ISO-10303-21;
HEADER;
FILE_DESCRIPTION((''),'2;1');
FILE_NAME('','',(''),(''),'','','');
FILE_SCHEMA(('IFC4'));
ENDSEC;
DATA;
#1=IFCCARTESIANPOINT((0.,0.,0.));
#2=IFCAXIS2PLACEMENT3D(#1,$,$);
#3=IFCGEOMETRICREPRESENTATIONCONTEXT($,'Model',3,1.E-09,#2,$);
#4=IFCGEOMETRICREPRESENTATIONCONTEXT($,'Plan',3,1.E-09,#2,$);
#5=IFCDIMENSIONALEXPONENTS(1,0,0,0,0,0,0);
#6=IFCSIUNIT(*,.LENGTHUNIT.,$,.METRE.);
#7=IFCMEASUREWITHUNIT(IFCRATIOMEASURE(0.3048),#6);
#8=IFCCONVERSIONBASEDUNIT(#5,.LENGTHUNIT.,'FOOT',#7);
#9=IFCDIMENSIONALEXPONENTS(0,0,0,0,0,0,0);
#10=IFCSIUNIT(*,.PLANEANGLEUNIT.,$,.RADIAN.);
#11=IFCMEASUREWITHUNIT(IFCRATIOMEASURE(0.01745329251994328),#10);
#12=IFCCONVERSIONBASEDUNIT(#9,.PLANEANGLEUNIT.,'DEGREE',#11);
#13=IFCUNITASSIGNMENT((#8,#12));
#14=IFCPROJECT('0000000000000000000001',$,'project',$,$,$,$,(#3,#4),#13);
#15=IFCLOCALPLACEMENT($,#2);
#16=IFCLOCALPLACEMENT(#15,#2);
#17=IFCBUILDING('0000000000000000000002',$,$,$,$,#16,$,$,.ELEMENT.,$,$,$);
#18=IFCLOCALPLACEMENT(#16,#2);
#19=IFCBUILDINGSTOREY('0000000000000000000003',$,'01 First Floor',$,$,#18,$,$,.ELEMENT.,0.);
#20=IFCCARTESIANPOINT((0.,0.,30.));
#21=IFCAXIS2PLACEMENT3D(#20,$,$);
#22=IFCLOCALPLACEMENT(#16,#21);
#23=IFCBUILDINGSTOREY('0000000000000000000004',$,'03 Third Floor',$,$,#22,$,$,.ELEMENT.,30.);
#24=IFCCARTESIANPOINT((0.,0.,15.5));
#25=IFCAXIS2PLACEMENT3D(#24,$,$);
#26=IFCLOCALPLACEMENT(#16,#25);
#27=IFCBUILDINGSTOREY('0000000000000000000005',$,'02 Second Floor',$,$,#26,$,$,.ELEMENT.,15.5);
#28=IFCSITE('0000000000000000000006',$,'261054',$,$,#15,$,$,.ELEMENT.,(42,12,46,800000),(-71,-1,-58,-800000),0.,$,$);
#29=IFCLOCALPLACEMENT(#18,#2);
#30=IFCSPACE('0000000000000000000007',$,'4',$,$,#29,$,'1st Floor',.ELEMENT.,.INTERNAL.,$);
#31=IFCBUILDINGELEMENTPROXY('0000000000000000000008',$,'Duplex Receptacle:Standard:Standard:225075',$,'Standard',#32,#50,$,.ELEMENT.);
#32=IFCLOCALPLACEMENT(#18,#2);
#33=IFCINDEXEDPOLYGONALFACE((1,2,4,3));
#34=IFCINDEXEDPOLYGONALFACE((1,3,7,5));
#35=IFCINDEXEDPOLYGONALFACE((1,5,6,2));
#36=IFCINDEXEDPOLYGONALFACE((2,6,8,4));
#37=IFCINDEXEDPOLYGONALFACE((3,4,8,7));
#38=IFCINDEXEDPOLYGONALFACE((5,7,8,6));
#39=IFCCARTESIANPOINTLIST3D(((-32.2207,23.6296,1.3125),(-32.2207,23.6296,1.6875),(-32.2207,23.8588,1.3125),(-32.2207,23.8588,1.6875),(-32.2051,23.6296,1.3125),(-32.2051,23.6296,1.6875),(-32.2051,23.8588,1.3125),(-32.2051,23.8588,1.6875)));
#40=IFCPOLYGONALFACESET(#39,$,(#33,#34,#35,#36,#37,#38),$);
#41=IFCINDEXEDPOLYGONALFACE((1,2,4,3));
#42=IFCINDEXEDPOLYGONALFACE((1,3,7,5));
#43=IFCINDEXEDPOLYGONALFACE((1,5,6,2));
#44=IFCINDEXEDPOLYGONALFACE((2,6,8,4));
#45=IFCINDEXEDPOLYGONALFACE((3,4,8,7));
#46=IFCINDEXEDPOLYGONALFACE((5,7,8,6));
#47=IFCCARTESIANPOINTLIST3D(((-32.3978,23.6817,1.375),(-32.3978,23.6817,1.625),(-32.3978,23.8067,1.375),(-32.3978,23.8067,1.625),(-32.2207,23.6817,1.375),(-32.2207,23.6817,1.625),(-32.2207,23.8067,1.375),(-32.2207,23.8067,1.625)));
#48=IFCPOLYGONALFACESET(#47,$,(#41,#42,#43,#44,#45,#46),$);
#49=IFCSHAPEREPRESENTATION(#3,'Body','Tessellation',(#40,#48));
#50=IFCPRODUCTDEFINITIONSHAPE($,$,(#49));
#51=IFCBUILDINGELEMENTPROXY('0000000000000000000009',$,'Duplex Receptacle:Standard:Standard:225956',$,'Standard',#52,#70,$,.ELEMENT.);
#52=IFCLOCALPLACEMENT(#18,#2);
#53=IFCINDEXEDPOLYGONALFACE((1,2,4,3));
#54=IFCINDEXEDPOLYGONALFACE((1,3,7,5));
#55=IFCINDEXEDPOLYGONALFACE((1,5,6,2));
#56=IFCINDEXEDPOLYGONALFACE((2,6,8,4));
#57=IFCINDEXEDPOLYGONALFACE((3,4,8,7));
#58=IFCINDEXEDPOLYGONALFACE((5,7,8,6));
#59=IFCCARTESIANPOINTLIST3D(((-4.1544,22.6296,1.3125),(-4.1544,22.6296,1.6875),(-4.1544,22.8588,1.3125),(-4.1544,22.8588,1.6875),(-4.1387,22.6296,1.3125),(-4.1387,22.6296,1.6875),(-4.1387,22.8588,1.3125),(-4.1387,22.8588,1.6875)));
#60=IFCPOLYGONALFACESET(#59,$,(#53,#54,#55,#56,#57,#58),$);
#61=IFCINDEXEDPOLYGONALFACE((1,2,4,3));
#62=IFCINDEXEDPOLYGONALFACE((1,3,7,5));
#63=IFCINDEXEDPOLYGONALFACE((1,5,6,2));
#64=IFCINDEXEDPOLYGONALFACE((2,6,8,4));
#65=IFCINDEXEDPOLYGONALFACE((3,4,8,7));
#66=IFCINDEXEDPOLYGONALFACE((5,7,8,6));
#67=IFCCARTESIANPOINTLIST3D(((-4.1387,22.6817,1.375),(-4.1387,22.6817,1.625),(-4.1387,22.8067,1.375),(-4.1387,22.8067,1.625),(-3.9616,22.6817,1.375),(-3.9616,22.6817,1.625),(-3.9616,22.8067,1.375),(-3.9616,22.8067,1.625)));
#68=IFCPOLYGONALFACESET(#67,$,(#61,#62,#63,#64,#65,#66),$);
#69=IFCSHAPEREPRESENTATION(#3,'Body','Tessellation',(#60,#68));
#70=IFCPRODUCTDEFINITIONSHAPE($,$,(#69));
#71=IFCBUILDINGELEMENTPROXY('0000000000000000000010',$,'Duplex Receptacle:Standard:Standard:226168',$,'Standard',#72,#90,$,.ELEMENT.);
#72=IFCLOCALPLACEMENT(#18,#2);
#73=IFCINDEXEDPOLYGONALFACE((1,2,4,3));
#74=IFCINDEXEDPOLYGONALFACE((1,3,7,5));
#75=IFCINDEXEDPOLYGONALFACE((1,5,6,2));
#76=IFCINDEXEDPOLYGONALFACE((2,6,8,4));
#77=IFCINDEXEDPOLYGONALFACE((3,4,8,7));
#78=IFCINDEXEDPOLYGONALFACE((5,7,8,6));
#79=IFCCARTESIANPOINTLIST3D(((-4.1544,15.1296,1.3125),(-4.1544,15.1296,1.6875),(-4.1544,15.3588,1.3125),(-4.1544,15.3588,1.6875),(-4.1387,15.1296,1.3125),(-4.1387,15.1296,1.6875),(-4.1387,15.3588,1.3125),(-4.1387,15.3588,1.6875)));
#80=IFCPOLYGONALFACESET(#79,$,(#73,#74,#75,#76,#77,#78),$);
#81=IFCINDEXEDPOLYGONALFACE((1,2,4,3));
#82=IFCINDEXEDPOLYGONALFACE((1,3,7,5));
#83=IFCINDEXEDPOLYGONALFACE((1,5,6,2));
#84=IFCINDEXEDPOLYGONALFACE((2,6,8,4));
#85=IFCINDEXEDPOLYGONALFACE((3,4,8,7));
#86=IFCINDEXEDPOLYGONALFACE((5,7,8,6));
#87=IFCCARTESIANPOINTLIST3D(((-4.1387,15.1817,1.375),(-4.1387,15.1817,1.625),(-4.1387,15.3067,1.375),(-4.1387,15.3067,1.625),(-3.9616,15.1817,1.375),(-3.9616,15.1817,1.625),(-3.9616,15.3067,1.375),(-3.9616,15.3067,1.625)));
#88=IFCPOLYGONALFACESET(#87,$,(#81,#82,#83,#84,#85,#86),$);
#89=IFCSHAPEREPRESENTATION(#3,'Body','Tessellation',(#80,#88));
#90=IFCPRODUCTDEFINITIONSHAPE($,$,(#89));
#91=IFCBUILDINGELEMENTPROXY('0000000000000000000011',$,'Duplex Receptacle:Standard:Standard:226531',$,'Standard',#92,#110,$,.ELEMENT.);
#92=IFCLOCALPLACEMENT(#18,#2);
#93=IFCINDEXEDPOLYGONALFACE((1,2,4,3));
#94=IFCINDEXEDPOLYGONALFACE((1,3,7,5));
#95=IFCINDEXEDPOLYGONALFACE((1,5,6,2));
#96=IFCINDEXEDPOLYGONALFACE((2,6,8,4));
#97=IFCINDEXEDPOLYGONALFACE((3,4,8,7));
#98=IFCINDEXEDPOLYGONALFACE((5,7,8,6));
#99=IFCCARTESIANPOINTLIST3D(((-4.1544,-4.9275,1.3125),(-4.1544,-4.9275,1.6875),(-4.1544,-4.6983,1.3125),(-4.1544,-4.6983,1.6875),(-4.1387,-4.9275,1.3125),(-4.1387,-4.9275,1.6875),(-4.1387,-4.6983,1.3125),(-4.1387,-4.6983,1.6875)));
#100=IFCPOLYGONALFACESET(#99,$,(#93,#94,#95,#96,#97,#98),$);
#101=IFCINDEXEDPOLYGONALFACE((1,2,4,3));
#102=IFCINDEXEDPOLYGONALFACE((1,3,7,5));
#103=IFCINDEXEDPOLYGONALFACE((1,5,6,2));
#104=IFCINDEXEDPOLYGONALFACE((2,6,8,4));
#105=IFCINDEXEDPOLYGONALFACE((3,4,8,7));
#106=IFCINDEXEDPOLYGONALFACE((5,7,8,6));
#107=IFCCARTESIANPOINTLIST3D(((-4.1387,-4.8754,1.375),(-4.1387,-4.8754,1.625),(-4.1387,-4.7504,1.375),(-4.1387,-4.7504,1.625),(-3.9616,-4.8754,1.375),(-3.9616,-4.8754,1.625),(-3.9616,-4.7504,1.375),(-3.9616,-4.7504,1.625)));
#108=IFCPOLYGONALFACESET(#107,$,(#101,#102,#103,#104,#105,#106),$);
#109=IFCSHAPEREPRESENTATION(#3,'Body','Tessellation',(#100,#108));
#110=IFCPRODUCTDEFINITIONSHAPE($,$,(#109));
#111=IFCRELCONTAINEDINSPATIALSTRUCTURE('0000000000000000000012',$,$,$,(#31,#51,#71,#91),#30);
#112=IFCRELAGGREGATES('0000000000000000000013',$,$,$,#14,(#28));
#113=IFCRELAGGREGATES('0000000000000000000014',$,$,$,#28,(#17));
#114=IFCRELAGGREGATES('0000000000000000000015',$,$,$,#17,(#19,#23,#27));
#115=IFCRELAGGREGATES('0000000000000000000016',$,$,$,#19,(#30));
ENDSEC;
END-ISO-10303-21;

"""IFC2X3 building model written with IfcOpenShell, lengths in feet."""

from ifc_helpers import new_model, entity, si_unit, converted_unit, frame, origin, origin_2d_with_axis, place, context, project, spatial, rectangle, extrude, source, transform, mapped, element, save


model = new_model("IFC2X3")

# Units and contexts
model_context = context("Model", 3, precision=1e-09, world=origin())
plan_context = context("Plan", 3, precision=1e-09, world=origin())
ifc_project = project(units=[converted_unit("LENGTHUNIT", "FOOT", entity("IfcRatioMeasure", 0.3048), si_unit("LENGTHUNIT", "METRE"), dimensions=[1, 0, 0, 0, 0, 0, 0]), converted_unit("PLANEANGLEUNIT", "DEGREE", entity("IfcRatioMeasure", 0.01745329251994328), si_unit("PLANEANGLEUNIT", "RADIAN"), dimensions=[0, 0, 0, 0, 0, 0, 0])], contexts=[model_context, plan_context])

# Site, building, storey
site_placement = place(None, origin())
site = spatial("IfcSite", under=ifc_project, at=site_placement, Name="261054", CompositionType="ELEMENT", RefLatitude=(42, 12, 46, 800000), RefLongitude=(-71, -1, -58, -800000), RefElevation=0.0)
building_placement = place(site_placement, origin())
building = spatial("IfcBuilding", under=site, at=building_placement, CompositionType="ELEMENT")
storey_1_placement = place(building_placement, origin())
storey_1 = spatial("IfcBuildingStorey", under=building, at=storey_1_placement, Name="01 First Floor", CompositionType="ELEMENT", Elevation=0.0)

# Shared definitions
storey_2_placement = place(building_placement, frame((0.0, 0.0, 30.0)))
storey_2 = spatial("IfcBuildingStorey", under=building, at=storey_2_placement, Name="03 Third Floor", CompositionType="ELEMENT", Elevation=30.0)

# Shared definitions
storey_3_placement = place(building_placement, frame((0.0, 0.0, 15.5)))
storey_3 = spatial("IfcBuildingStorey", under=building, at=storey_3_placement, Name="02 Second Floor", CompositionType="ELEMENT", Elevation=15.5)

# Shared definitions
space_placement = place(storey_1_placement, origin())
space = spatial("IfcSpace", under=storey_1, at=space_placement, Name="4", LongName="1st Floor", CompositionType="ELEMENT", InteriorOrExteriorSpace="INTERNAL")

# Building element proxies
shared_shape_1 = source(origin(), model_context, "Body", "SweptSolid", [
    extrude(rectangle(XDim=0.2292, YDim=0.375, at=origin_2d_with_axis()), frame((0.0, 0.0, 0.0), z_axis=(0.0, 0.0, 1.0), x_axis=(-1.0, 0.0, 0.0)), (0.0, 0.0, 1.0), 0.0156),
    extrude(rectangle(XDim=0.125, YDim=0.25, at=origin_2d_with_axis()), frame((0.0, 0.0, -0.1771), z_axis=(0.0, 0.0, 1.0), x_axis=(-1.0, 0.0, 0.0)), (0.0, 0.0, 1.0), 0.1771),
])
for number, where, z_axis, x_axis, name in (
    (1, (-32.2207, 23.7442, 1.5), (1.0, 0.0, 0.0), (0.0, 1.0, 0.0), "Duplex Receptacle:Standard:Standard:225075"),
    (2, (-4.1387, 22.7442, 1.5), (-1.0, 0.0, 0.0), (0.0, -1.0, 0.0), "Duplex Receptacle:Standard:Standard:225956"),
    (3, (-4.1387, 15.2442, 1.5), (-1.0, 0.0, 0.0), (0.0, -1.0, 0.0), "Duplex Receptacle:Standard:Standard:226168"),
    (4, (-4.1387, -4.8129, 1.5), (-1.0, 0.0, 0.0), (0.0, -1.0, 0.0), "Duplex Receptacle:Standard:Standard:226531"),
):
    element("IfcBuildingElementProxy", number, at=place(space_placement, frame(where, z_axis=z_axis, x_axis=x_axis)), inside=space, Name=name, ObjectType="Standard", CompositionType="ELEMENT", context=model_context, shape_type="MappedRepresentation", body=[
        mapped(shared_shape_1, transform((0.0, 0.0, 0.0), scale=1.0)),
    ])

save(model, "model.ifc")
